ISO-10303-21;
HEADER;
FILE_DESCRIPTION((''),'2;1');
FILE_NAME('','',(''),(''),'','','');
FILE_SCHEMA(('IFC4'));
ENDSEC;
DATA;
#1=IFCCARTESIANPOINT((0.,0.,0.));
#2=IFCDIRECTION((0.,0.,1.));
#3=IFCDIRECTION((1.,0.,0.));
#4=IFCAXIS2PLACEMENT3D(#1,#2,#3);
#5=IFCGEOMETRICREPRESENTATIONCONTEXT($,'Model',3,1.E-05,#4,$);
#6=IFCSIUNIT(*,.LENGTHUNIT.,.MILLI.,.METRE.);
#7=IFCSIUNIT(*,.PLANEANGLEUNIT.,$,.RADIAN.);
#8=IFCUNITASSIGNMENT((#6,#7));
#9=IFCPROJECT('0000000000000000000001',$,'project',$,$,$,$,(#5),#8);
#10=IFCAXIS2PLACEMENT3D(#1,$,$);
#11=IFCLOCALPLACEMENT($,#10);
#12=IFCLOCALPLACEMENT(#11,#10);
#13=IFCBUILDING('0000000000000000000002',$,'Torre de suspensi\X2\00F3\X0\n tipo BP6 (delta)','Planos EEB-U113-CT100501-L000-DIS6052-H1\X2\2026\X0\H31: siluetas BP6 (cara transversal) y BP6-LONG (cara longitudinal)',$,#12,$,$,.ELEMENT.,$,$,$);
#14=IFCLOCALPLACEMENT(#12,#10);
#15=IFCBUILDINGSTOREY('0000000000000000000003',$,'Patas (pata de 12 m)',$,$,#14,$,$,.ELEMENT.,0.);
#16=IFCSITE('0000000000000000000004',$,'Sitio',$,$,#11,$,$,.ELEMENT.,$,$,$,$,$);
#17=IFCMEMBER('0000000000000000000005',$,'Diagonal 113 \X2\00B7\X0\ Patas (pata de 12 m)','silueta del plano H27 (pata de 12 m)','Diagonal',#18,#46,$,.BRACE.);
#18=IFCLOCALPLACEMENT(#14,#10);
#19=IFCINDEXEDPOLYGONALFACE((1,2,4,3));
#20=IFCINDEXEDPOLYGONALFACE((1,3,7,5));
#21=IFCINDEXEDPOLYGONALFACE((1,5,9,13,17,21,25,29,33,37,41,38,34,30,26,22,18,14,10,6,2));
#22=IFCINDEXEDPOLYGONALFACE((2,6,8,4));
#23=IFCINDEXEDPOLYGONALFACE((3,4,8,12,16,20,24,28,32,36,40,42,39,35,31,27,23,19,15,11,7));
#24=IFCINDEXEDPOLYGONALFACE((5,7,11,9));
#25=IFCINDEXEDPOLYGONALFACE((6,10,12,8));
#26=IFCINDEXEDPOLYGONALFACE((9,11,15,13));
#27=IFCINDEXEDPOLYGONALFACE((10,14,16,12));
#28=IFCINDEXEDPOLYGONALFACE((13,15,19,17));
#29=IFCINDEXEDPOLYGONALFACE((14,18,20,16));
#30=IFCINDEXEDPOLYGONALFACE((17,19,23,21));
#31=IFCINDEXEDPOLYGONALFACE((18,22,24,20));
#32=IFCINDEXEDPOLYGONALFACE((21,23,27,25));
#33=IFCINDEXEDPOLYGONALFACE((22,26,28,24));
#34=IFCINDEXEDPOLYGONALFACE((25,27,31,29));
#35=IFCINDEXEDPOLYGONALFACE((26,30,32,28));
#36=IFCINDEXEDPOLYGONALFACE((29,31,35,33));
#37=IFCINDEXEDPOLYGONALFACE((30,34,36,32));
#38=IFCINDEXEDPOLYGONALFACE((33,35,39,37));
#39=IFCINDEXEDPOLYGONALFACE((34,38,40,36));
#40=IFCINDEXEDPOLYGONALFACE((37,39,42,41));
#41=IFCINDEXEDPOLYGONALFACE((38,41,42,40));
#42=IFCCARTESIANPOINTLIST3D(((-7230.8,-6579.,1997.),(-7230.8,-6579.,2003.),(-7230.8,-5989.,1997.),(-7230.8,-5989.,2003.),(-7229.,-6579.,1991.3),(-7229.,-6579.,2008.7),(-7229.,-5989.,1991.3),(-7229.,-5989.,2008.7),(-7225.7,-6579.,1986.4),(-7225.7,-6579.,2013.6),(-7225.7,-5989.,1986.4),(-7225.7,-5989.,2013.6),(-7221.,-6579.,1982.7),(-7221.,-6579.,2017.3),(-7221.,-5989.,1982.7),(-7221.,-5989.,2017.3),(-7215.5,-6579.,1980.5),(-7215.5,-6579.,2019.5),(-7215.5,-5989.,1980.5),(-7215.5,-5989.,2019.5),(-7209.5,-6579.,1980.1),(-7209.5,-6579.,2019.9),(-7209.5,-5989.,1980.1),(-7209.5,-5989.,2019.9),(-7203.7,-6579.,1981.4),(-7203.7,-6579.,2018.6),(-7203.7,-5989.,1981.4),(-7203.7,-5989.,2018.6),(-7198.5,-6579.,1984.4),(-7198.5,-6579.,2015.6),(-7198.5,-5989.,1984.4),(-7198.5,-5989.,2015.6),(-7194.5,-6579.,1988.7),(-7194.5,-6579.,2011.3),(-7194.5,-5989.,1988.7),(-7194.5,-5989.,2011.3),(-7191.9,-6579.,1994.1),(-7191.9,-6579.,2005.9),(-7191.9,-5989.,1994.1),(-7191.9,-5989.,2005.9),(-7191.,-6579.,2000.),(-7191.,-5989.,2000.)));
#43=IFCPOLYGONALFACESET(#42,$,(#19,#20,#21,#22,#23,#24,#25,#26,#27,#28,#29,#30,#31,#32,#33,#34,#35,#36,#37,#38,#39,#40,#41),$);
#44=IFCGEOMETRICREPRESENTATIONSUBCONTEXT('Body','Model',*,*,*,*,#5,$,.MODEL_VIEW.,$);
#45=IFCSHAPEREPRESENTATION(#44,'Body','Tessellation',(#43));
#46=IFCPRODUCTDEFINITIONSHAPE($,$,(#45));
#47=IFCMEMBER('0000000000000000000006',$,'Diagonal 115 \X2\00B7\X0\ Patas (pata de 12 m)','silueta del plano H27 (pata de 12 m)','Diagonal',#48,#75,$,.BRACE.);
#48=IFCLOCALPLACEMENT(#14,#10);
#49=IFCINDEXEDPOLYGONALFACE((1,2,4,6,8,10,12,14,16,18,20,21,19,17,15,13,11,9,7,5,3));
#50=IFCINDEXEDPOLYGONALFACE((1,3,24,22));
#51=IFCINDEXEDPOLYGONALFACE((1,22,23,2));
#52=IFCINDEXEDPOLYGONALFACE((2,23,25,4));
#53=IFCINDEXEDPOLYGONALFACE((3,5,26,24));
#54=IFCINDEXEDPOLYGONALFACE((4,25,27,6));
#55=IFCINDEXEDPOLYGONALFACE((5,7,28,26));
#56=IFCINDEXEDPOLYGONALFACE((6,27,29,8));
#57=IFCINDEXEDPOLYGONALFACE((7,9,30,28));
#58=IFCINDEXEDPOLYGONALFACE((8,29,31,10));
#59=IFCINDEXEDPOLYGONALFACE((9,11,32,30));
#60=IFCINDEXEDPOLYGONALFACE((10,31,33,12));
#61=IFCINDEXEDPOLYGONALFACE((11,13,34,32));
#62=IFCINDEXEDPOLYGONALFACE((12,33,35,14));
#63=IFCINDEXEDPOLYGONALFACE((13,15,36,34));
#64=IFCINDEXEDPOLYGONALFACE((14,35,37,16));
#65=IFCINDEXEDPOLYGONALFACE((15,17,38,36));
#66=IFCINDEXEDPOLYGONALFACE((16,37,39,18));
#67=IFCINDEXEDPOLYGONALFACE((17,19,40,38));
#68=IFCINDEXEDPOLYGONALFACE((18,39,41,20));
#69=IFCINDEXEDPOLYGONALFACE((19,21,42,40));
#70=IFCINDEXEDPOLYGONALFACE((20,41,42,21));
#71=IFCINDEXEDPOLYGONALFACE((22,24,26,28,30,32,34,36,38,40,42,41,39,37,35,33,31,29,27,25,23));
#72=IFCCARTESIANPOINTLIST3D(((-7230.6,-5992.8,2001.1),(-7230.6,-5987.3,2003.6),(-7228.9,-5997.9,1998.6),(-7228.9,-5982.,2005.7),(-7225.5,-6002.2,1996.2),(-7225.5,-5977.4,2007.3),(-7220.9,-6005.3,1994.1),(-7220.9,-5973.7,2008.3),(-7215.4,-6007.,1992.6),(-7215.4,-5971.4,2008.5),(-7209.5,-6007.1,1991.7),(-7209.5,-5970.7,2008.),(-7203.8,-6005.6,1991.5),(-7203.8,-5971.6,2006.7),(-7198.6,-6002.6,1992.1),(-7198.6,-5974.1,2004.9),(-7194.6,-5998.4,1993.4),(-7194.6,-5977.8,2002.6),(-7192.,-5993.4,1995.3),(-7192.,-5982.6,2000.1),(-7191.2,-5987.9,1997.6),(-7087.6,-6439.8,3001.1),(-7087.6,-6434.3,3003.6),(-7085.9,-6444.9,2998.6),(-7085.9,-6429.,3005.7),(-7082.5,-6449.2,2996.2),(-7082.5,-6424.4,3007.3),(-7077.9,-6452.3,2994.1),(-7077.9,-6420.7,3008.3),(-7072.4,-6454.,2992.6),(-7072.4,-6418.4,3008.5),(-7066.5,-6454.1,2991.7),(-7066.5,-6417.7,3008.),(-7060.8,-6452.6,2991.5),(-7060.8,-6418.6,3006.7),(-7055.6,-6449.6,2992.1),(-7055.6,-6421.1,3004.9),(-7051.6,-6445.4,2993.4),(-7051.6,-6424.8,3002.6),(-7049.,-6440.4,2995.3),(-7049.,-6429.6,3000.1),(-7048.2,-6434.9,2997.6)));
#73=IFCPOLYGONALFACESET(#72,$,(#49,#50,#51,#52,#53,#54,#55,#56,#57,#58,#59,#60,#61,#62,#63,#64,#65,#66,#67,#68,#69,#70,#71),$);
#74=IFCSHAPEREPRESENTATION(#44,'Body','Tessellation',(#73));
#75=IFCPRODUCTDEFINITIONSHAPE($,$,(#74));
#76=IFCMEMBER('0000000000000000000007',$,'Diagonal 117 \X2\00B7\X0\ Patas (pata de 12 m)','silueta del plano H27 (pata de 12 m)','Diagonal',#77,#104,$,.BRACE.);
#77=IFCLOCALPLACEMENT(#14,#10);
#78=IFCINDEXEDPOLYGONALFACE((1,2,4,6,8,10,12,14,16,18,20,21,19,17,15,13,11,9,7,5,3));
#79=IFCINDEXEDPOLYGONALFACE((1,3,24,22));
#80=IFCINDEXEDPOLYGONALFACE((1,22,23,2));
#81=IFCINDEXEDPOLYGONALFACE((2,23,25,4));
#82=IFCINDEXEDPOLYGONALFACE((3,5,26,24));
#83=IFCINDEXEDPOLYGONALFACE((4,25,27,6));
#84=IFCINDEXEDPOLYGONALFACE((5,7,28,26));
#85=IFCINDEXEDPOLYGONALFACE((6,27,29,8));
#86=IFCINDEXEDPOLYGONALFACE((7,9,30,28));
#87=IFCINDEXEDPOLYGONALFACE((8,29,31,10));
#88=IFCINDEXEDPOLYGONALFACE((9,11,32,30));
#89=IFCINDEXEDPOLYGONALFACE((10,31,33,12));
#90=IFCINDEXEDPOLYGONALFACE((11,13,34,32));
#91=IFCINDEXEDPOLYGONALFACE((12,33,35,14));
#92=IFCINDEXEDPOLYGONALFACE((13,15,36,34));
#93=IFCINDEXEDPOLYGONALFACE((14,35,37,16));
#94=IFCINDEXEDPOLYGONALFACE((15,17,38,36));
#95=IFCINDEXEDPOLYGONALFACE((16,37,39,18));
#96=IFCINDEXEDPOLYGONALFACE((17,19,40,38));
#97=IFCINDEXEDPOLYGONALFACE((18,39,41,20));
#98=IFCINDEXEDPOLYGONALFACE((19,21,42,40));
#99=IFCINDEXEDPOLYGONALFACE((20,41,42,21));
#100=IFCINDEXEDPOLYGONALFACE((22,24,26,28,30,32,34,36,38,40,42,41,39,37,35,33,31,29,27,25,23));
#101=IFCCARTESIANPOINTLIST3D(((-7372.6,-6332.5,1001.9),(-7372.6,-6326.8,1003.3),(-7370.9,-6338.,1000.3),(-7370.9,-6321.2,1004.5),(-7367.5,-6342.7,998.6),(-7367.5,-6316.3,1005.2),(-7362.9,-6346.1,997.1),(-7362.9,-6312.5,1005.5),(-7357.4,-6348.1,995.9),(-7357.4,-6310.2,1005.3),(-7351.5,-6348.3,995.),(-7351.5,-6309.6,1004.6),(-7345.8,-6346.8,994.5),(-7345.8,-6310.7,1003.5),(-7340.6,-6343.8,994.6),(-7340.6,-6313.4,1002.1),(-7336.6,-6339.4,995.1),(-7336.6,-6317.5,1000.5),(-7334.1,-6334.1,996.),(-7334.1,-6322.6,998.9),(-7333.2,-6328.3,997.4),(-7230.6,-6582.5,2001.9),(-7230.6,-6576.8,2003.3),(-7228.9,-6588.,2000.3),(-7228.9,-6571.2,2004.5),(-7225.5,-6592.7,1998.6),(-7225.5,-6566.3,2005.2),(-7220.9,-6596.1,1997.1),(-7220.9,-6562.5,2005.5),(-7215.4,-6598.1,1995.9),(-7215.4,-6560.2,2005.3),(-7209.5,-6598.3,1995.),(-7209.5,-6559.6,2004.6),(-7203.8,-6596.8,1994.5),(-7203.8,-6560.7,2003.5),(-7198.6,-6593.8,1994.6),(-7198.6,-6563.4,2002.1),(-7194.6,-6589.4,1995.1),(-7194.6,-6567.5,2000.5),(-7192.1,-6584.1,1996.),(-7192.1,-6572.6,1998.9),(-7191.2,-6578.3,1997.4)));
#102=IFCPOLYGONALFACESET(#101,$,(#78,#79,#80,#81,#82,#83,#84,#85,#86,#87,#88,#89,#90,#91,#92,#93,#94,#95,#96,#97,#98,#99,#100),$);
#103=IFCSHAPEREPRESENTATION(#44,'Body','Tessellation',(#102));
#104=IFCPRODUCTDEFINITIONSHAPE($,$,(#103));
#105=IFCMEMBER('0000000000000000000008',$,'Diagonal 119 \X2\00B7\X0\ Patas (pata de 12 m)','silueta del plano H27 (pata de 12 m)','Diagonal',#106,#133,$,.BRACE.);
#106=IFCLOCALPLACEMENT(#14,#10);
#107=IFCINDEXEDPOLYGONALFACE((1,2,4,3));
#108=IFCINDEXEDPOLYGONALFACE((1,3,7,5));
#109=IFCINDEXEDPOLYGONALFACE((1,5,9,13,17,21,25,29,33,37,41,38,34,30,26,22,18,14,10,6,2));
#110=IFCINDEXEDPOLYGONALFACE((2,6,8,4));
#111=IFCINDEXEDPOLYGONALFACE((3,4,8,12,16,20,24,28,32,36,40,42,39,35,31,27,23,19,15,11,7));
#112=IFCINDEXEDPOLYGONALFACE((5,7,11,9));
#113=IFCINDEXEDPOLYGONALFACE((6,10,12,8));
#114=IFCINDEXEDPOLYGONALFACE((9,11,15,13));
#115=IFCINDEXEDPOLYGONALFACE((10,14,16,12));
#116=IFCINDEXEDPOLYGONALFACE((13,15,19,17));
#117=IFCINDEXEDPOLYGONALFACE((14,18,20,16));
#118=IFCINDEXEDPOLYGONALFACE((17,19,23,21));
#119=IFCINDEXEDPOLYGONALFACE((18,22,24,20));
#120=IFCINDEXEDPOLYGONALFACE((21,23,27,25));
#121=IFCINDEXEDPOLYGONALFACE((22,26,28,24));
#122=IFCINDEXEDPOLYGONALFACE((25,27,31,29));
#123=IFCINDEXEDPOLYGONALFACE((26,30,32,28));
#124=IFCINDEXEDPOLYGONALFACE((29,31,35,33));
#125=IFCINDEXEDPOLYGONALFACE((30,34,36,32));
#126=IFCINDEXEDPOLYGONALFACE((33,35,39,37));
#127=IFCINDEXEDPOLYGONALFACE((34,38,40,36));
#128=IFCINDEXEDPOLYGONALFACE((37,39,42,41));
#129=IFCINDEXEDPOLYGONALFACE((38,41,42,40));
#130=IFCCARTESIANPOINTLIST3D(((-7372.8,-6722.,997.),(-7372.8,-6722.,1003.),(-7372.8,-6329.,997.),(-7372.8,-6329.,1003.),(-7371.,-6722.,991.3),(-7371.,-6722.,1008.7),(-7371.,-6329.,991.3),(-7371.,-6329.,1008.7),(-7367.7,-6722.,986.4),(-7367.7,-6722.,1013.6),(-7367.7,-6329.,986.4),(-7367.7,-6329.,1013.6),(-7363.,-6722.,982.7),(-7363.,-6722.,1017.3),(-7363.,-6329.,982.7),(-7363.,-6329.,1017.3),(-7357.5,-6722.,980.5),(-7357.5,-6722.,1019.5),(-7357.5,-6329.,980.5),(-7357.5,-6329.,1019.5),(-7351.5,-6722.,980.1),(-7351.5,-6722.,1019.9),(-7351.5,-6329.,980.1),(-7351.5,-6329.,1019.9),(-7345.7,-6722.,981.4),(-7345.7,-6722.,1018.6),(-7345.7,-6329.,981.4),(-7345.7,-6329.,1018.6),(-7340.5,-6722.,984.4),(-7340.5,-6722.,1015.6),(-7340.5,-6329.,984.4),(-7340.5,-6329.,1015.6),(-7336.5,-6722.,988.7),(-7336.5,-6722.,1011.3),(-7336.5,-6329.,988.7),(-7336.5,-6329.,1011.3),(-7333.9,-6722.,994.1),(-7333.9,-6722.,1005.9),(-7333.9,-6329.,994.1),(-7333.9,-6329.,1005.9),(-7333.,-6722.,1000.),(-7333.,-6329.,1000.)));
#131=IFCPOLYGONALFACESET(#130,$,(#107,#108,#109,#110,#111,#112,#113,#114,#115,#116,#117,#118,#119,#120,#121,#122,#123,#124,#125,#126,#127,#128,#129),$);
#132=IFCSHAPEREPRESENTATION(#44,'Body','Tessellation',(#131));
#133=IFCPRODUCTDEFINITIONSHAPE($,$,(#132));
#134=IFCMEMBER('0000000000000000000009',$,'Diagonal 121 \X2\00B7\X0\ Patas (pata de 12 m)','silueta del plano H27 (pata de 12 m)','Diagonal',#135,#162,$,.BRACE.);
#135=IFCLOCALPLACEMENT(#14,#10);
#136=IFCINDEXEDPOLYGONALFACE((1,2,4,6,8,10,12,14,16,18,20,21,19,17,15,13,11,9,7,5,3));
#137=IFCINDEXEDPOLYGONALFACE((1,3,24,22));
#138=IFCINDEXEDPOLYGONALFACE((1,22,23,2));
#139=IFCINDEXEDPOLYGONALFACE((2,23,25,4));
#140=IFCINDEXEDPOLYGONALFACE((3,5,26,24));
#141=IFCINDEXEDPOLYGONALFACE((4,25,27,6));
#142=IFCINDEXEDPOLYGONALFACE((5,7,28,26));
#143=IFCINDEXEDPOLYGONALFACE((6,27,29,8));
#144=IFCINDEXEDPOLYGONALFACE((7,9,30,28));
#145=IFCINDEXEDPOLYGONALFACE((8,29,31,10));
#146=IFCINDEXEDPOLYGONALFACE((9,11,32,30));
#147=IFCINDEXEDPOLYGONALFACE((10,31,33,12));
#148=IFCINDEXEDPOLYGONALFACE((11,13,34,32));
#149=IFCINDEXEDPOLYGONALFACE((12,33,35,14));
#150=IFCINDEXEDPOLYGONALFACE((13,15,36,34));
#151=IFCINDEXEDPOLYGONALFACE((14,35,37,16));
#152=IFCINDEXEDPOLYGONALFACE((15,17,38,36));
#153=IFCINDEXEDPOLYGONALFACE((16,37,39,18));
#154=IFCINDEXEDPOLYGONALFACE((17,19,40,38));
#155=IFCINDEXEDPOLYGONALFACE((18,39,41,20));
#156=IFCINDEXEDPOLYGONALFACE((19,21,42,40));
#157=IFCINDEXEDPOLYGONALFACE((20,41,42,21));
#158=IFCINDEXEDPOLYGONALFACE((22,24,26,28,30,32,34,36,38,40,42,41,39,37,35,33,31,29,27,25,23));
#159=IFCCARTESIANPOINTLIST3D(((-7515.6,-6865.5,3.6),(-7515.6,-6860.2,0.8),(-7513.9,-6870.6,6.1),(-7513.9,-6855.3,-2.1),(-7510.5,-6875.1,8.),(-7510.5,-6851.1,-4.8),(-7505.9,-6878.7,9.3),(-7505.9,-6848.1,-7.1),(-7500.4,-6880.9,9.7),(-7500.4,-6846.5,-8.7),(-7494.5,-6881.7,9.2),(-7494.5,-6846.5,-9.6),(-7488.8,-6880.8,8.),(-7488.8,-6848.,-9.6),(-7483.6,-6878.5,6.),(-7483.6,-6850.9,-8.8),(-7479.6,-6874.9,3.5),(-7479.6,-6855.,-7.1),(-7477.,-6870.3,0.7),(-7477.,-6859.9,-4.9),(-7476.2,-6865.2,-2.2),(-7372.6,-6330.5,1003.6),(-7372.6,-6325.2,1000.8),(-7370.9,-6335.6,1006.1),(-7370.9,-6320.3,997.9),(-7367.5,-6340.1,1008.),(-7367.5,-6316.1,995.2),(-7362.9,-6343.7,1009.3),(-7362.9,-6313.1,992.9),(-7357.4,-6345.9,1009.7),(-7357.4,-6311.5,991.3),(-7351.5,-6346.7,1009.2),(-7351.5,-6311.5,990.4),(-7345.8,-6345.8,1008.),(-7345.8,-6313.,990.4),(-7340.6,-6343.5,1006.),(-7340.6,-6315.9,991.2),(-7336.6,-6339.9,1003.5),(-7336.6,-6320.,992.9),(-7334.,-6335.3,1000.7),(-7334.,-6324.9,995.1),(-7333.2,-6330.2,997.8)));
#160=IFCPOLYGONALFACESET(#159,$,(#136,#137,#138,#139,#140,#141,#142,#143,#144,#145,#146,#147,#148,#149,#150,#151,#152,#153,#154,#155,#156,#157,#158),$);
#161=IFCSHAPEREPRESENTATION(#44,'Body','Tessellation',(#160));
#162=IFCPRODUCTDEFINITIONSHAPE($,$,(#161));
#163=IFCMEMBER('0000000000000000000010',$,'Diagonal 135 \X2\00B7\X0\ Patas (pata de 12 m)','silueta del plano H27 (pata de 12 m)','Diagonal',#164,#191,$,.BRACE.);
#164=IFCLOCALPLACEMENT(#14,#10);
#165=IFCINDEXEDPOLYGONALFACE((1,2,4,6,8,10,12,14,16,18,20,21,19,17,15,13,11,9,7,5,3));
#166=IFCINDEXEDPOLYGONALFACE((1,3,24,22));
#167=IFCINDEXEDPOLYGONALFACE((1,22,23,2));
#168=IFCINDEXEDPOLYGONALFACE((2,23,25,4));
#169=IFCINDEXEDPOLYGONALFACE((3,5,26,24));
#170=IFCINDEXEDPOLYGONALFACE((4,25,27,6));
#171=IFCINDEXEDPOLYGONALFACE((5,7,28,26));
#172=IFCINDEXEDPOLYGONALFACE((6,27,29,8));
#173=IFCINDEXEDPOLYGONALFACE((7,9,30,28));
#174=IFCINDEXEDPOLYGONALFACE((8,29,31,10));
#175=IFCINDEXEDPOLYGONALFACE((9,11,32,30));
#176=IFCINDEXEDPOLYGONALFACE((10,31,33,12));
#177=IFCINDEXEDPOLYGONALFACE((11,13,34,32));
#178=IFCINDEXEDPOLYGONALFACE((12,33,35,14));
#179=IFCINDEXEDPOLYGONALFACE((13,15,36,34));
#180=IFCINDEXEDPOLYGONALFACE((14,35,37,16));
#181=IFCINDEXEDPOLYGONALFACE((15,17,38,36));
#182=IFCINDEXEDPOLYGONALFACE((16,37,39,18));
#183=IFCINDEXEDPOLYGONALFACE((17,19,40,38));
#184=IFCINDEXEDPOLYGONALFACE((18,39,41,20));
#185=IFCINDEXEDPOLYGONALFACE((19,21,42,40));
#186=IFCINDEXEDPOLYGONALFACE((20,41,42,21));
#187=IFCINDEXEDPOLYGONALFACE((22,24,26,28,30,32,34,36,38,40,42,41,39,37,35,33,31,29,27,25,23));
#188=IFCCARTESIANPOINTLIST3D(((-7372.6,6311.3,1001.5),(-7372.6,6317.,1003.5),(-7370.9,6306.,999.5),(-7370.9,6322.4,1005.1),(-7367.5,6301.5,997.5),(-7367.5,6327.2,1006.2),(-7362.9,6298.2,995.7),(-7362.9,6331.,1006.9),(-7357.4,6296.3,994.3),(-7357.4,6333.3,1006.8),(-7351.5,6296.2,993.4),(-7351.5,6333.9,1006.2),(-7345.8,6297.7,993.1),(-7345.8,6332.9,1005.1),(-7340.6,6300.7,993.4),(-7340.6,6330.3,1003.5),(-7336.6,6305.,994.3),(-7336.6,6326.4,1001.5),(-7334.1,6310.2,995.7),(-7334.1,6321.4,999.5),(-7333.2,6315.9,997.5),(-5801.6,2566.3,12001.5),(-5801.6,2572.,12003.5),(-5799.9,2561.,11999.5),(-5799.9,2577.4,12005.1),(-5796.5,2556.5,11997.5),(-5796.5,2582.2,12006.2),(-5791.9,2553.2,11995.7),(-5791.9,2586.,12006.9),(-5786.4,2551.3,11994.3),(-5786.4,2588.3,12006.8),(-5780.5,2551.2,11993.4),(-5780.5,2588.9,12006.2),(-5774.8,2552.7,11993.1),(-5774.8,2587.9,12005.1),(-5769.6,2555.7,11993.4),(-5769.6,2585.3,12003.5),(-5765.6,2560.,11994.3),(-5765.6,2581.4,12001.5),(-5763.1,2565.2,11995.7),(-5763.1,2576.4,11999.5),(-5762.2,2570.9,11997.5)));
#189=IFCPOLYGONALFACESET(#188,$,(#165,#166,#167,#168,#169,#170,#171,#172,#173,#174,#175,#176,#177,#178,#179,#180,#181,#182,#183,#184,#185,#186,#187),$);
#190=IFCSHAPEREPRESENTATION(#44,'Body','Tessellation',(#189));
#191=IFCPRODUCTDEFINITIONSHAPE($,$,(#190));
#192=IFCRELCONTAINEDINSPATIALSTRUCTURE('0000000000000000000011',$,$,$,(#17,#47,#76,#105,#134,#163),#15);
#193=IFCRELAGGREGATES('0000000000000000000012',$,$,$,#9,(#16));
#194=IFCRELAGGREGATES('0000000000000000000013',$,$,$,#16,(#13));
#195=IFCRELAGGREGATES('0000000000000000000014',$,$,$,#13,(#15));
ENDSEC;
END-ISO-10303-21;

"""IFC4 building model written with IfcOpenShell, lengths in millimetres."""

from ifc_helpers import new_model, si_unit, frame, origin, origin_with_axes, place, context, subcontext, project, spatial, circle, extrude, element, save


model = new_model("IFC4")

# Units and contexts
model_context = context("Model", 3, precision=1e-05, world=origin_with_axes())
body_context = subcontext(model_context, "Body", "Model", "MODEL_VIEW")
ifc_project = project(units=[si_unit("LENGTHUNIT", "METRE", prefix="MILLI"), si_unit("PLANEANGLEUNIT", "RADIAN")], contexts=[model_context])

# Site, building, storey
site_placement = place(None, origin())
site = spatial("IfcSite", under=ifc_project, at=site_placement, Name="Sitio", CompositionType="ELEMENT")
building_placement = place(site_placement, origin())
building = spatial("IfcBuilding", under=site, at=building_placement, Name="Torre de suspensión tipo BP6 (delta)", Description="Planos EEB-U113-CT100501-L000-DIS6052-H1…H31: siluetas BP6 (cara transversal) y BP6-LONG (cara longitudinal)", CompositionType="ELEMENT")
storey_placement = place(building_placement, origin())
storey = spatial("IfcBuildingStorey", under=building, at=storey_placement, Name="Patas (pata de 12 m)", CompositionType="ELEMENT", Elevation=0.0)

# Members
member_1_placement = place(storey_placement, frame((-7211.0, -6579.0, 2000.0), z_axis=(0.0, 1.0, 0.0), x_axis=(1.0, 0.0, 0.0)))
element("IfcMember", 1, at=member_1_placement, inside=storey, Name="Diagonal 113 · Patas (pata de 12 m)", Description="silueta del plano H27 (pata de 12 m)", ObjectType="Diagonal", PredefinedType="BRACE", context=body_context, shape_type="SweptSolid", body=[
    extrude(circle(Radius=20.0), None, (0.0, 0.0, 1.0), 590.0),
])
member_2_placement = place(storey_placement, frame((-7211.0, -5989.0, 2000.0), z_axis=(0.129452, -0.404652, 0.905262), x_axis=(0.991586, 0.052828, -0.118183)))
element("IfcMember", 2, at=member_2_placement, inside=storey, Name="Diagonal 115 · Patas (pata de 12 m)", Description="silueta del plano H27 (pata de 12 m)", ObjectType="Diagonal", PredefinedType="BRACE", context=body_context, shape_type="SweptSolid", body=[
    extrude(circle(Radius=20.0), None, (0.0, 0.0, 1.0), 1104.7),
])
member_3_placement = place(storey_placement, frame((-7353.0, -6329.0, 1000.0), z_axis=(0.136471, -0.240266, 0.961066), x_axis=(0.990644, 0.033099, -0.132397)))
element("IfcMember", 3, at=member_3_placement, inside=storey, Name="Diagonal 117 · Patas (pata de 12 m)", Description="silueta del plano H27 (pata de 12 m)", ObjectType="Diagonal", PredefinedType="BRACE", context=body_context, shape_type="SweptSolid", body=[
    extrude(circle(Radius=20.0), None, (0.0, 0.0, 1.0), 1040.5),
])
member_4_placement = place(storey_placement, frame((-7353.0, -6722.0, 1000.0), z_axis=(0.0, 1.0, 0.0), x_axis=(1.0, 0.0, 0.0)))
element("IfcMember", 4, at=member_4_placement, inside=storey, Name="Diagonal 119 · Patas (pata de 12 m)", Description="silueta del plano H27 (pata de 12 m)", ObjectType="Diagonal", PredefinedType="BRACE", context=body_context, shape_type="SweptSolid", body=[
    extrude(circle(Radius=20.0), None, (0.0, 0.0, 1.0), 393.0),
])
member_5_placement = place(storey_placement, frame((-7496.0, -6864.0, 0.0), z_axis=(0.125099, 0.468026, 0.874815), x_axis=(0.992144, -0.059013, -0.110305)))
element("IfcMember", 5, at=member_5_placement, inside=storey, Name="Diagonal 121 · Patas (pata de 12 m)", Description="silueta del plano H27 (pata de 12 m)", ObjectType="Diagonal", PredefinedType="BRACE", context=body_context, shape_type="SweptSolid", body=[
    extrude(circle(Radius=20.0), None, (0.0, 0.0, 1.0), 1143.1),
])
member_6_placement = place(storey_placement, frame((-5782.0, 2570.0, 12000.0), z_axis=(-0.133979, 0.319383, -0.938107), x_axis=(0.990984, 0.04318, -0.12683)))
element("IfcMember", 6, at=member_6_placement, inside=storey, Name="Diagonal 135 · Patas (pata de 12 m)", Description="silueta del plano H27 (pata de 12 m)", ObjectType="Diagonal", PredefinedType="BRACE", context=body_context, shape_type="SweptSolid", body=[
    extrude(circle(Radius=20.0), None, (0.0, 0.0, 1.0), 11725.7),
])

save(model, "model.ifc")
